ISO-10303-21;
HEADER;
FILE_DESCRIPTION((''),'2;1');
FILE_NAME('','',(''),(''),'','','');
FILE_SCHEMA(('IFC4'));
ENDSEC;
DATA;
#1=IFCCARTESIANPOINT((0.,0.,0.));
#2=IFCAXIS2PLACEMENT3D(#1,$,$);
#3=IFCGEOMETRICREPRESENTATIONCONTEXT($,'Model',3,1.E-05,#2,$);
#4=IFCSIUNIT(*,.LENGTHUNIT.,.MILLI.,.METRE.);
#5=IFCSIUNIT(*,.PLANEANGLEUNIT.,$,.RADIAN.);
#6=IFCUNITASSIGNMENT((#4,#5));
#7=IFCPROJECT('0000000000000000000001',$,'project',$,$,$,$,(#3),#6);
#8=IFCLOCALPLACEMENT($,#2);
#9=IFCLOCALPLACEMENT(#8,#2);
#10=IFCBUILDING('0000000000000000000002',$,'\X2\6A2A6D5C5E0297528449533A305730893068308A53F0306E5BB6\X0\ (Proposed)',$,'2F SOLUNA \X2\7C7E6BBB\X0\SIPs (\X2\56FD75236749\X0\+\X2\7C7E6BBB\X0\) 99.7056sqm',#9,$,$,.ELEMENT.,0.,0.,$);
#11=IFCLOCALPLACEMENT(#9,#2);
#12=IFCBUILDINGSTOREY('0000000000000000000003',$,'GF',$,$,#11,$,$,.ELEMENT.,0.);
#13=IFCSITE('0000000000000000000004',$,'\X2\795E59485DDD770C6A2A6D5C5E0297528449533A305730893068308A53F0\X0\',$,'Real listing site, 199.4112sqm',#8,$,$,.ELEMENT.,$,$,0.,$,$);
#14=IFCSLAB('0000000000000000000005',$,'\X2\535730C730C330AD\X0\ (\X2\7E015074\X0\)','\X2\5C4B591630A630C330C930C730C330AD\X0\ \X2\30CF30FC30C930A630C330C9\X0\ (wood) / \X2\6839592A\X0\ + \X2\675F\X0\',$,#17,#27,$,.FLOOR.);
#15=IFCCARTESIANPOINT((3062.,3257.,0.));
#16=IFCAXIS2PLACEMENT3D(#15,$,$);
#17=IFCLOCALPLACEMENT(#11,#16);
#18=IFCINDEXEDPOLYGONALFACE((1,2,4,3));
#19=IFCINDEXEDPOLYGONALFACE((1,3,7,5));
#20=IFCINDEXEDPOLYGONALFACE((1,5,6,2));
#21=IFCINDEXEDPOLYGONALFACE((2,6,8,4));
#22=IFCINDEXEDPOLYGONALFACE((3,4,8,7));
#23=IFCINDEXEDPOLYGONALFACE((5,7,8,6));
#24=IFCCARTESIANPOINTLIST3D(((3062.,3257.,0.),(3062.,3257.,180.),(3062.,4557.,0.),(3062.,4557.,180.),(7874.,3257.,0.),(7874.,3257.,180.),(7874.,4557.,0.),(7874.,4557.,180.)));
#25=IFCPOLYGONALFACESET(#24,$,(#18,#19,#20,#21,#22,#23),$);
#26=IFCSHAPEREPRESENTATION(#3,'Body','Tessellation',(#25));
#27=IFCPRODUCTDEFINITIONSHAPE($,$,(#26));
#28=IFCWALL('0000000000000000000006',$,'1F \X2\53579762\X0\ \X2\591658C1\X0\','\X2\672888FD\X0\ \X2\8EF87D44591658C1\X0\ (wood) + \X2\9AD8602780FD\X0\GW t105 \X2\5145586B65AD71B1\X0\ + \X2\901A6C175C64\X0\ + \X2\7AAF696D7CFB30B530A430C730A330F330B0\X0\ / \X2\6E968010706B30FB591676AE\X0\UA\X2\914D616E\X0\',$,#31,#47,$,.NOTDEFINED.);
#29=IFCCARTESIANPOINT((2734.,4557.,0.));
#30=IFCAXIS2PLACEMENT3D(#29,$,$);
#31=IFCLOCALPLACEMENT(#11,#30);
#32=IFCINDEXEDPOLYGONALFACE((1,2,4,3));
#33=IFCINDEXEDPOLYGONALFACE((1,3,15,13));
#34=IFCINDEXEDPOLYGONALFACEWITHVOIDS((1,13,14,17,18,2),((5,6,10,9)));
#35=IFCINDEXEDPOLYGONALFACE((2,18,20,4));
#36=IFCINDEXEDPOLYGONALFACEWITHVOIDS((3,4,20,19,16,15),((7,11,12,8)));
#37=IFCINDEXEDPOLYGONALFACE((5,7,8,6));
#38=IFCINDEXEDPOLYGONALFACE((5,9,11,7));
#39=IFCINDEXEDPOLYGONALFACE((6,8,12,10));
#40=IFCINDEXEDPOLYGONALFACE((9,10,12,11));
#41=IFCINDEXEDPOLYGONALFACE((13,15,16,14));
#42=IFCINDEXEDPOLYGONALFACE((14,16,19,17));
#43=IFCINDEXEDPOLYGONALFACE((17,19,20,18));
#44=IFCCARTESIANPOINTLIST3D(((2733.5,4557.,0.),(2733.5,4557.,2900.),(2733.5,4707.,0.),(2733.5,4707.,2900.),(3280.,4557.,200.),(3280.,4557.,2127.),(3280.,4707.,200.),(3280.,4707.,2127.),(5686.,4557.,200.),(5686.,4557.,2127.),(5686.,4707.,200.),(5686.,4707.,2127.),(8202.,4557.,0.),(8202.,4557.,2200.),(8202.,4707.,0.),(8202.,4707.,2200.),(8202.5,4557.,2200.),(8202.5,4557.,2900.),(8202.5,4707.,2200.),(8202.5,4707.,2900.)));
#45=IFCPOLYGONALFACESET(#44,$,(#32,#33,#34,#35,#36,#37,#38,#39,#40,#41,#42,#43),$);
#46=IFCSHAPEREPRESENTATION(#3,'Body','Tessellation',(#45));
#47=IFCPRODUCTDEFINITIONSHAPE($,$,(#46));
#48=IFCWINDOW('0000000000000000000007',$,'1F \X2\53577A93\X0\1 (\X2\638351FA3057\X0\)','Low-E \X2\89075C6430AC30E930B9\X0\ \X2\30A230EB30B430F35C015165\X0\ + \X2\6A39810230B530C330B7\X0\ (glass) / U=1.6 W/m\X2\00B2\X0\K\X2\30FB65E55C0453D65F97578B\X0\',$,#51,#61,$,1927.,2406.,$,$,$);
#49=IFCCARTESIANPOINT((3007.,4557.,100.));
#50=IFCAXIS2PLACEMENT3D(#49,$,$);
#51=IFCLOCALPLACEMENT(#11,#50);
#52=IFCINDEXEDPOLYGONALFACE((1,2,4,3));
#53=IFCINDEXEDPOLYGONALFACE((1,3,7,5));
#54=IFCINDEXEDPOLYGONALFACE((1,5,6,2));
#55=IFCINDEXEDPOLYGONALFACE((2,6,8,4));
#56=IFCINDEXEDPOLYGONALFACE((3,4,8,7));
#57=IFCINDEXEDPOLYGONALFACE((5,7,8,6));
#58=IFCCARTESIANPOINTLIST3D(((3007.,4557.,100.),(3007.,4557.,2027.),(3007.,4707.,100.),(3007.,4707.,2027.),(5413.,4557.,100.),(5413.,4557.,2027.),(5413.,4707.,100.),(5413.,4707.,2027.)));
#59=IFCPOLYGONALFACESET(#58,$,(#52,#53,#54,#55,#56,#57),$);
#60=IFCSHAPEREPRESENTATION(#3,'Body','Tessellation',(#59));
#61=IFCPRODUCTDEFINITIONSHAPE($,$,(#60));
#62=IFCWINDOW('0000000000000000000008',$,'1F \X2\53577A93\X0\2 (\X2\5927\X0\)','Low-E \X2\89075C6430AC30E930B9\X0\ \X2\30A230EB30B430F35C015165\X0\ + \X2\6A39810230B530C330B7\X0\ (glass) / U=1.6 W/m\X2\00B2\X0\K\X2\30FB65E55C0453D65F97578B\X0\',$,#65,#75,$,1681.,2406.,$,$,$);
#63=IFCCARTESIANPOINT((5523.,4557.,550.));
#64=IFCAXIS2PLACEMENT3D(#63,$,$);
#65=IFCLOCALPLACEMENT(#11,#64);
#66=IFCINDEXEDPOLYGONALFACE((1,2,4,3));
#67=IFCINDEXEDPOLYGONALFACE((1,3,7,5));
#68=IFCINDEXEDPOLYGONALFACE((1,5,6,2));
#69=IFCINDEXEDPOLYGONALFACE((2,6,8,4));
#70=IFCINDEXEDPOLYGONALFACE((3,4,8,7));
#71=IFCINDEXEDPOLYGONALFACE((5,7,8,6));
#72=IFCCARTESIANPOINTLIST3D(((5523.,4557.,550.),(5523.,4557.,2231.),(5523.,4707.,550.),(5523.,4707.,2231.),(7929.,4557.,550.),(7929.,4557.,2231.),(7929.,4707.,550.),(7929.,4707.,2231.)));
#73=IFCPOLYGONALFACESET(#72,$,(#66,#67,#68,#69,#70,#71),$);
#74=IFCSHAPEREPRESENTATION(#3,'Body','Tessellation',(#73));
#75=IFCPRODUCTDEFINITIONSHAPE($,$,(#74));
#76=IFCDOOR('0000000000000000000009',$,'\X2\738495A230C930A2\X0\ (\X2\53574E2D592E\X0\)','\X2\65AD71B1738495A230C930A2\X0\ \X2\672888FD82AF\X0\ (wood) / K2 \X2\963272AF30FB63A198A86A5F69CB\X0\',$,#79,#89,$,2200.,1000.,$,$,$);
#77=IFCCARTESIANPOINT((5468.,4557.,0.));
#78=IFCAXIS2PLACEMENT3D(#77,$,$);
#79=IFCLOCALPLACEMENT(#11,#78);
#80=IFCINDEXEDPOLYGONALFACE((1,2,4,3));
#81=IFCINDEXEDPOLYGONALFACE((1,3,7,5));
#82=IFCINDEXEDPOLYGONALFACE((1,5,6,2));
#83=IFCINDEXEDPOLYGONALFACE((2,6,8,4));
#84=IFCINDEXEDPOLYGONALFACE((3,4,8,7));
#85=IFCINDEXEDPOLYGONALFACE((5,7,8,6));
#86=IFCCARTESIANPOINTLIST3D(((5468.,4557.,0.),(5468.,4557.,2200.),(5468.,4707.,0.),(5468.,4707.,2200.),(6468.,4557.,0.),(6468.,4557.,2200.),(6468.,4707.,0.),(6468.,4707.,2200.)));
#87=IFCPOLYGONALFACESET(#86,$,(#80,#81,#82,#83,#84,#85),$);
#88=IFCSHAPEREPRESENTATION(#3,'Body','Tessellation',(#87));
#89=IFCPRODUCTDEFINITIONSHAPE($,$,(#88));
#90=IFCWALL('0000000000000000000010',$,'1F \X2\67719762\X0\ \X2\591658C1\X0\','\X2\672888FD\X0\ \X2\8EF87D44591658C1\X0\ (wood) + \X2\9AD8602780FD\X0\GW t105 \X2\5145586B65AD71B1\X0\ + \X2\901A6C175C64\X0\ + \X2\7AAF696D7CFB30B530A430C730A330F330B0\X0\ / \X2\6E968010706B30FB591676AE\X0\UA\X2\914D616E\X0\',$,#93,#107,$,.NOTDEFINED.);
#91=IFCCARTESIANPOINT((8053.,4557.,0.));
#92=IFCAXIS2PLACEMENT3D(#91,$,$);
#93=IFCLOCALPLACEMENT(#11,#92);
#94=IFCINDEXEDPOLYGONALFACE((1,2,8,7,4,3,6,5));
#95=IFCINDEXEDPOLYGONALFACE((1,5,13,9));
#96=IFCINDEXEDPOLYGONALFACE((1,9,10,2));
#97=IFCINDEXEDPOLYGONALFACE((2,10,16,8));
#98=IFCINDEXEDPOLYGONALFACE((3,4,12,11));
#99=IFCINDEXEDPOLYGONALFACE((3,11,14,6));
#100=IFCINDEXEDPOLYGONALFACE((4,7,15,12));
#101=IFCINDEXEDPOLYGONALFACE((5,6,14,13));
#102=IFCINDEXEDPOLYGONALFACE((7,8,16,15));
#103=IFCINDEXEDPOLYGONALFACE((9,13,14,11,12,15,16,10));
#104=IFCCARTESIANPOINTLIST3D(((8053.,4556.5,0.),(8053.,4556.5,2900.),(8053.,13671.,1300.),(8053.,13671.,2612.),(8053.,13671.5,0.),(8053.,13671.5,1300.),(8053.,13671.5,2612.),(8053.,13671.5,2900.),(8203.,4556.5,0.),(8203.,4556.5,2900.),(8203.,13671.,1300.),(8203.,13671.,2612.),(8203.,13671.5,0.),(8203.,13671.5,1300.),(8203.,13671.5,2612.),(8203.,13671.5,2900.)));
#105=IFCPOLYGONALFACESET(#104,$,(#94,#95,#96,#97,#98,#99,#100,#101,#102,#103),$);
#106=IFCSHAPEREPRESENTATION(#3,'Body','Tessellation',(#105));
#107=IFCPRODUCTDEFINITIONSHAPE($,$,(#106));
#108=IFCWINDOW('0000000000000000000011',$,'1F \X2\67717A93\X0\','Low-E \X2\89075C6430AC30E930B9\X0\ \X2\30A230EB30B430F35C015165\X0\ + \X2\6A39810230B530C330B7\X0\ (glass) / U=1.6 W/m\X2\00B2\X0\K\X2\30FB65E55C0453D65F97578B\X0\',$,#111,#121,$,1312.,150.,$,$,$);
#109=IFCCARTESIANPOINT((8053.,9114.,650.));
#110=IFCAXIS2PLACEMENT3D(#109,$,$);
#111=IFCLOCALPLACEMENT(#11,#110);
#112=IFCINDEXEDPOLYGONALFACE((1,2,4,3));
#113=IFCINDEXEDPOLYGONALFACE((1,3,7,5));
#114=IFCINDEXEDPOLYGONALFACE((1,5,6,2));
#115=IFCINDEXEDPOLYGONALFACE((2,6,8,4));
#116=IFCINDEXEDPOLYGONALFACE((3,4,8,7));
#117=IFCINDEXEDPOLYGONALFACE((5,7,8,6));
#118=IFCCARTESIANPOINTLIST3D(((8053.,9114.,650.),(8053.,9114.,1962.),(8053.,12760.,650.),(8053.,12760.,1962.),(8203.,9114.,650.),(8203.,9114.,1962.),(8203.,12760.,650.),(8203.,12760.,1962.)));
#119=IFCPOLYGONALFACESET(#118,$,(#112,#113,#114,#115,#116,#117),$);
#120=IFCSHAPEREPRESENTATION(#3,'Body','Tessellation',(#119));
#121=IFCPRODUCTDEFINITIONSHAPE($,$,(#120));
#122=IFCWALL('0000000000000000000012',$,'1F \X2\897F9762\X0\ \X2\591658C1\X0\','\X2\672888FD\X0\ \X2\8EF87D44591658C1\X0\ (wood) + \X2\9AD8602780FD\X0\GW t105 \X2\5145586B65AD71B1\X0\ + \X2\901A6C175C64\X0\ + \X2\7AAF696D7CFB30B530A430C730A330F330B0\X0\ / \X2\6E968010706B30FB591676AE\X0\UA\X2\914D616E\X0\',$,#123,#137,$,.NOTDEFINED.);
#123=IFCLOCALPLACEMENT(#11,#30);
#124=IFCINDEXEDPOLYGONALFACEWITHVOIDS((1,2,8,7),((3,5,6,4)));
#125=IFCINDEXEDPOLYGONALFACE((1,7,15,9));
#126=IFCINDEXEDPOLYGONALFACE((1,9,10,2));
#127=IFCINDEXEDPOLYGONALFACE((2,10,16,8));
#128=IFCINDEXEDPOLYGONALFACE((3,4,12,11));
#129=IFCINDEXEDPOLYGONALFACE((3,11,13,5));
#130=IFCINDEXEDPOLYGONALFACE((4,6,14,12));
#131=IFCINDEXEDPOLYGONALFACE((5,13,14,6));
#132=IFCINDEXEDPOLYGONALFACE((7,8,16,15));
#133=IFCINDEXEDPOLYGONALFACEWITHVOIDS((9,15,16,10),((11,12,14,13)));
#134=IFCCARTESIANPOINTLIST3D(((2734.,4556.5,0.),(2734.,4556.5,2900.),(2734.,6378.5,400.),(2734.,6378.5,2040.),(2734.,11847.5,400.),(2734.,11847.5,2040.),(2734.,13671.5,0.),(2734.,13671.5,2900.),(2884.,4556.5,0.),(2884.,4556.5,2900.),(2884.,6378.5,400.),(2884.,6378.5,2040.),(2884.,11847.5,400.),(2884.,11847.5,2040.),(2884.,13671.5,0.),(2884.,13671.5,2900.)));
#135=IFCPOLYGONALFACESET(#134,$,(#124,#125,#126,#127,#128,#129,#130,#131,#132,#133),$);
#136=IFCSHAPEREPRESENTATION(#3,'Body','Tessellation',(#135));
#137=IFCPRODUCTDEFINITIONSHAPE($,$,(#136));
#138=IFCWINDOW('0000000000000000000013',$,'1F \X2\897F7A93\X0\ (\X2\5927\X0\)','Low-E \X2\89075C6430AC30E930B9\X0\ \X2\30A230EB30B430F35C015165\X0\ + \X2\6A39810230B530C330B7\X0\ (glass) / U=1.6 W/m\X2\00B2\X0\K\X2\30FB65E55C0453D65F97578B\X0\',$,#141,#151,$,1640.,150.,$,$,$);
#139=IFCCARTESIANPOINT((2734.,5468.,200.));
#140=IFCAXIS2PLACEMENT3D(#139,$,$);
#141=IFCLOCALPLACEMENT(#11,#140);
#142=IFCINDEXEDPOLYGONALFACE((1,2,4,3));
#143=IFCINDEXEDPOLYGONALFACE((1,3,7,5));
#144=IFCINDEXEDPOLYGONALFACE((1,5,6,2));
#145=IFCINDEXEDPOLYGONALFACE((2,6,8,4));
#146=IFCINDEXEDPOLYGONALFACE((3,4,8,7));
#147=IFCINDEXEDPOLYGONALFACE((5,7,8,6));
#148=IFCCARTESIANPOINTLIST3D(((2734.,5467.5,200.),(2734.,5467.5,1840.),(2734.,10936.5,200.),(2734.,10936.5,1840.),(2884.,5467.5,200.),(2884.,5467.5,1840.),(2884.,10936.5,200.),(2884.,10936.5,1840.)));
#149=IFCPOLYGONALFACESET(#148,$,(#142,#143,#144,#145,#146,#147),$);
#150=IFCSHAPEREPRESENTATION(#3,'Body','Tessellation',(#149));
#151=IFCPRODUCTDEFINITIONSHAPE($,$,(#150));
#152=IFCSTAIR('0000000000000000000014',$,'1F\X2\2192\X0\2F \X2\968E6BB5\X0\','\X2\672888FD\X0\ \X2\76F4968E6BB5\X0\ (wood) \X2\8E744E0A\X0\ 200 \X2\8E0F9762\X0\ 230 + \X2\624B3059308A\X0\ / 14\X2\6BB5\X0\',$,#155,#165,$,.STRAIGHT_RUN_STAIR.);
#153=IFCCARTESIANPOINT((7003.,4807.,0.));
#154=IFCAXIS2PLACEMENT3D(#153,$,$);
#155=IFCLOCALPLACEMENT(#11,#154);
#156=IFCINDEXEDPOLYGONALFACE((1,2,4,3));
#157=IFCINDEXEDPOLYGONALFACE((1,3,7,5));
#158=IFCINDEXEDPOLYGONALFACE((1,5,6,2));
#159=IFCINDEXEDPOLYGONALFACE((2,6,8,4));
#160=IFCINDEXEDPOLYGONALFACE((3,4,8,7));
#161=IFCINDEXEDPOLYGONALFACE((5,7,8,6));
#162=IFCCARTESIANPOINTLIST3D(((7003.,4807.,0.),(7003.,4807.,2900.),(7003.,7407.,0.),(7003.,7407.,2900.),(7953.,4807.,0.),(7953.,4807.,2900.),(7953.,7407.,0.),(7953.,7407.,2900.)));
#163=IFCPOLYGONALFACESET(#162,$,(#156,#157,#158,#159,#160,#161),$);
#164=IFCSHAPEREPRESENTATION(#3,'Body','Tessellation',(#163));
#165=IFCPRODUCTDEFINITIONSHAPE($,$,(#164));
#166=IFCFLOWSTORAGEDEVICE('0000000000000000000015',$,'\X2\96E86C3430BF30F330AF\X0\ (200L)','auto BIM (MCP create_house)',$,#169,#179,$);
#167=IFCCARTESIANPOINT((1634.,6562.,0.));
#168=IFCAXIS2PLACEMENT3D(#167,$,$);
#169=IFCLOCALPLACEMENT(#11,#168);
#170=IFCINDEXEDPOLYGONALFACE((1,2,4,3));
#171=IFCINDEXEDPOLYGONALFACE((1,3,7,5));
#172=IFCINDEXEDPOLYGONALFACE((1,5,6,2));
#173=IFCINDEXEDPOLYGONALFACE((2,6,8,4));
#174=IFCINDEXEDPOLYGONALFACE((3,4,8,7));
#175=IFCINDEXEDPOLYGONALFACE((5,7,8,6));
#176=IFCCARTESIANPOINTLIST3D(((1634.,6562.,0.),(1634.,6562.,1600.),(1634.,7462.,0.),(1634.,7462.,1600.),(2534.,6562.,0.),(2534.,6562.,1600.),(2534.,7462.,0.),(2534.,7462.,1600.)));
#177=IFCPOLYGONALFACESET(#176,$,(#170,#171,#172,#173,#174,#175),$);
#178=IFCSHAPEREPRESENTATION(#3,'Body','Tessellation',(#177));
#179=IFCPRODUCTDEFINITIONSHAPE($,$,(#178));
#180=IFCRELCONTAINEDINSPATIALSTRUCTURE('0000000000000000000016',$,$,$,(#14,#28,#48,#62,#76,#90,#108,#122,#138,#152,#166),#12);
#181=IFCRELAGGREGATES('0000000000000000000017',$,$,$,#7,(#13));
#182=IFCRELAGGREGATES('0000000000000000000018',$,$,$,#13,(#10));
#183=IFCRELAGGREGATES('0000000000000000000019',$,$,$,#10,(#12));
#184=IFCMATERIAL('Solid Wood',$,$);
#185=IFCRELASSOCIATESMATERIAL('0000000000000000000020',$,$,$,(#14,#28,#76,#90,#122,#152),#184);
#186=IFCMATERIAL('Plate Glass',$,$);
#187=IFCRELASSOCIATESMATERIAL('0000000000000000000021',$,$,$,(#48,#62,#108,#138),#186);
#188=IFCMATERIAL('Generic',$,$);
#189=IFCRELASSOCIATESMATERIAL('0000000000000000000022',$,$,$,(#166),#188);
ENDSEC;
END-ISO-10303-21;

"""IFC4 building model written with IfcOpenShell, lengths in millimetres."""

from ifc_helpers import new_model, si_unit, frame, frame_2d, origin, place, context, project, spatial, rectangle, extrude, material, element, fill, save


model = new_model("IFC4")

# Units and contexts
model_context = context("Model", 3, precision=1e-05, world=origin())
ifc_project = project(units=[si_unit("LENGTHUNIT", "METRE", prefix="MILLI"), si_unit("PLANEANGLEUNIT", "RADIAN")], contexts=[model_context])

# Site, building, storey
site_placement = place(None, origin())
site = spatial("IfcSite", under=ifc_project, at=site_placement, Name="神奈川県横浜市青葉区しらとり台", ObjectType="Real listing site, 199.4112sqm", CompositionType="ELEMENT", RefElevation=0.0)
building_placement = place(site_placement, origin())
building = spatial("IfcBuilding", under=site, at=building_placement, Name="横浜市青葉区しらとり台の家 (Proposed)", ObjectType="2F SOLUNA 籾殻SIPs (国産杉+籾殻) 99.7056sqm", CompositionType="ELEMENT", ElevationOfRefHeight=0.0, ElevationOfTerrain=0.0)
storey_placement = place(building_placement, origin())
storey = spatial("IfcBuildingStorey", under=building, at=storey_placement, Name="GF", CompositionType="ELEMENT", Elevation=0.0)

# Slab
ifc_material_1 = material(Name="Solid Wood")
slab_1_placement = place(storey_placement, frame((3062.0, 3257.0, 0.0)))
element("IfcSlab", 1, at=slab_1_placement, inside=storey, material=ifc_material_1, Name="南デッキ (縁側)", Description="屋外ウッドデッキ ハードウッド (wood) / 根太 + 束", PredefinedType="FLOOR", context=model_context, shape_type="SweptSolid", body=[
    extrude(rectangle(XDim=4812.0, YDim=1300.0, at=frame_2d((2406.0, 650.0))), frame((3062.0, 3257.0, 0.0)), (0.0, 0.0, 1.0), 180.0),
])

# Wall, openings, windows, door
wall_1_placement = place(storey_placement, frame((2734.0, 4557.0, 0.0)))
wall_1 = element("IfcWall", 2, at=wall_1_placement, inside=storey, material=ifc_material_1, Name="1F 南面 外壁", Description="木製 軸組外壁 (wood) + 高性能GW t105 充填断熱 + 通気層 + 窯業系サイディング / 準耐火・外皮UA配慮", PredefinedType="NOTDEFINED", context=model_context, shape_type="SweptSolid", body=[
    extrude(rectangle(XDim=5469.0, YDim=150.0, at=frame_2d((2734.0, 75.0))), frame((2734.0, 4557.0, 0.0)), (0.0, 0.0, 1.0), 2900.0),
])
opening_1_placement = place(storey_placement, frame((3007.0, 4557.0, 100.0)))
opening_1 = element("IfcOpeningElement", 3, at=opening_1_placement, cuts=wall_1, PredefinedType="NOTDEFINED", context=model_context, shape_type="SweptSolid", body=[
    extrude(rectangle(XDim=2406.0, YDim=150.0, at=frame_2d((1203.0, 75.0))), frame((3007.0, 4557.0, 100.0)), (0.0, 0.0, 1.0), 1927.0),
])
opening_2_placement = place(storey_placement, frame((5523.0, 4557.0, 550.0)))
opening_2 = element("IfcOpeningElement", 4, at=opening_2_placement, cuts=wall_1, PredefinedType="NOTDEFINED", context=model_context, shape_type="SweptSolid", body=[
    extrude(rectangle(XDim=2406.0, YDim=150.0, at=frame_2d((1203.0, 75.0))), frame((5523.0, 4557.0, 550.0)), (0.0, 0.0, 1.0), 1681.0),
])
opening_3_placement = place(storey_placement, frame((5468.0, 4557.0, 0.0)))
opening_3 = element("IfcOpeningElement", 5, at=opening_3_placement, cuts=wall_1, PredefinedType="NOTDEFINED", context=model_context, shape_type="SweptSolid", body=[
    extrude(rectangle(XDim=1000.0, YDim=150.0, at=frame_2d((500.0, 75.0))), frame((5468.0, 4557.0, 0.0)), (0.0, 0.0, 1.0), 2200.0),
])
ifc_material_2 = material(Name="Plate Glass")
window_1_placement = place(storey_placement, frame((3007.0, 4557.0, 100.0)))
window_1 = element("IfcWindow", 6, at=window_1_placement, inside=storey, material=ifc_material_2, Name="1F 南窓1 (掃出し)", Description="Low-E 複層ガラス アルゴン封入 + 樹脂サッシ (glass) / U=1.6 W/m²K・日射取得型", OverallHeight=1927.0, OverallWidth=2406.0, context=model_context, shape_type="SweptSolid", body=[
    extrude(rectangle(XDim=2406.0, YDim=150.0, at=frame_2d((1203.0, 75.0))), frame((3007.0, 4557.0, 100.0)), (0.0, 0.0, 1.0), 1927.0),
])
fill(opening_1, window_1)
window_2_placement = place(storey_placement, frame((5523.0, 4557.0, 550.0)))
window_2 = element("IfcWindow", 7, at=window_2_placement, inside=storey, material=ifc_material_2, Name="1F 南窓2 (大)", Description="Low-E 複層ガラス アルゴン封入 + 樹脂サッシ (glass) / U=1.6 W/m²K・日射取得型", OverallHeight=1681.0, OverallWidth=2406.0, context=model_context, shape_type="SweptSolid", body=[
    extrude(rectangle(XDim=2406.0, YDim=150.0, at=frame_2d((1203.0, 75.0))), frame((5523.0, 4557.0, 550.0)), (0.0, 0.0, 1.0), 1681.0),
])
fill(opening_2, window_2)
door_placement = place(storey_placement, frame((5468.0, 4557.0, 0.0)))
door = element("IfcDoor", 8, at=door_placement, inside=storey, material=ifc_material_1, Name="玄関ドア (南中央)", Description="断熱玄関ドア 木製芯 (wood) / K2 防犯・採風機構", OverallHeight=2200.0, OverallWidth=1000.0, context=model_context, shape_type="SweptSolid", body=[
    extrude(rectangle(XDim=1000.0, YDim=150.0, at=frame_2d((500.0, 75.0))), frame((5468.0, 4557.0, 0.0)), (0.0, 0.0, 1.0), 2200.0),
])
fill(opening_3, door)

# Walls, openings, windows
wall_2_placement = place(storey_placement, frame((8053.0, 4557.0, 0.0)))
wall_2 = element("IfcWall", 9, at=wall_2_placement, inside=storey, material=ifc_material_1, Name="1F 東面 外壁", Description="木製 軸組外壁 (wood) + 高性能GW t105 充填断熱 + 通気層 + 窯業系サイディング / 準耐火・外皮UA配慮", PredefinedType="NOTDEFINED", context=model_context, shape_type="SweptSolid", body=[
    extrude(rectangle(XDim=150.0, YDim=9115.0, at=frame_2d((75.0, 4557.0))), frame((8053.0, 4557.0, 0.0)), (0.0, 0.0, 1.0), 2900.0),
])
opening_4_placement = place(storey_placement, frame((8053.0, 9114.0, 650.0)))
opening_4 = element("IfcOpeningElement", 10, at=opening_4_placement, cuts=wall_2, PredefinedType="NOTDEFINED", context=model_context, shape_type="SweptSolid", body=[
    extrude(rectangle(XDim=150.0, YDim=3646.0, at=frame_2d((75.0, 1823.0))), frame((8053.0, 9114.0, 650.0)), (0.0, 0.0, 1.0), 1312.0),
])
window_3_placement = place(storey_placement, frame((8053.0, 9114.0, 650.0)))
window_3 = element("IfcWindow", 11, at=window_3_placement, inside=storey, material=ifc_material_2, Name="1F 東窓", Description="Low-E 複層ガラス アルゴン封入 + 樹脂サッシ (glass) / U=1.6 W/m²K・日射取得型", OverallHeight=1312.0, OverallWidth=150.0, context=model_context, shape_type="SweptSolid", body=[
    extrude(rectangle(XDim=150.0, YDim=3646.0, at=frame_2d((75.0, 1823.0))), frame((8053.0, 9114.0, 650.0)), (0.0, 0.0, 1.0), 1312.0),
])
fill(opening_4, window_3)
wall_3_placement = place(storey_placement, frame((2734.0, 4557.0, 0.0)))
wall_3 = element("IfcWall", 12, at=wall_3_placement, inside=storey, material=ifc_material_1, Name="1F 西面 外壁", Description="木製 軸組外壁 (wood) + 高性能GW t105 充填断熱 + 通気層 + 窯業系サイディング / 準耐火・外皮UA配慮", PredefinedType="NOTDEFINED", context=model_context, shape_type="SweptSolid", body=[
    extrude(rectangle(XDim=150.0, YDim=9115.0, at=frame_2d((75.0, 4557.0))), frame((2734.0, 4557.0, 0.0)), (0.0, 0.0, 1.0), 2900.0),
])
opening_5_placement = place(storey_placement, frame((2734.0, 5468.0, 200.0)))
opening_5 = element("IfcOpeningElement", 13, at=opening_5_placement, cuts=wall_3, PredefinedType="NOTDEFINED", context=model_context, shape_type="SweptSolid", body=[
    extrude(rectangle(XDim=150.0, YDim=5469.0, at=frame_2d((75.0, 2734.0))), frame((2734.0, 5468.0, 200.0)), (0.0, 0.0, 1.0), 1640.0),
])
window_4_placement = place(storey_placement, frame((2734.0, 5468.0, 200.0)))
window_4 = element("IfcWindow", 14, at=window_4_placement, inside=storey, material=ifc_material_2, Name="1F 西窓 (大)", Description="Low-E 複層ガラス アルゴン封入 + 樹脂サッシ (glass) / U=1.6 W/m²K・日射取得型", OverallHeight=1640.0, OverallWidth=150.0, context=model_context, shape_type="SweptSolid", body=[
    extrude(rectangle(XDim=150.0, YDim=5469.0, at=frame_2d((75.0, 2734.0))), frame((2734.0, 5468.0, 200.0)), (0.0, 0.0, 1.0), 1640.0),
])
fill(opening_5, window_4)

# Stair
stair_placement = place(storey_placement, frame((7003.0, 4807.0, 0.0)))
element("IfcStair", 15, at=stair_placement, inside=storey, material=ifc_material_1, Name="1F→2F 階段", Description="木製 直階段 (wood) 蹴上 200 踏面 230 + 手すり / 14段", PredefinedType="STRAIGHT_RUN_STAIR", context=model_context, shape_type="SweptSolid", body=[
    extrude(rectangle(XDim=950.0, YDim=2600.0, at=frame_2d((475.0, 1300.0))), frame((7003.0, 4807.0, 0.0)), (0.0, 0.0, 1.0), 2900.0),
])

# Shared definitions
ifc_material_3 = material(Name="Generic")

# Flow storage device
flow_storage_device_placement = place(storey_placement, frame((1634.0, 6562.0, 0.0)))
element("IfcFlowStorageDevice", 16, at=flow_storage_device_placement, inside=storey, material=ifc_material_3, Name="雨水タンク (200L)", Description="auto BIM (MCP create_house)", context=model_context, shape_type="SweptSolid", body=[
    extrude(rectangle(XDim=900.0, YDim=900.0, at=frame_2d((450.0, 450.0))), frame((1634.0, 6562.0, 0.0)), (0.0, 0.0, 1.0), 1600.0),
])

save(model, "model.ifc")
